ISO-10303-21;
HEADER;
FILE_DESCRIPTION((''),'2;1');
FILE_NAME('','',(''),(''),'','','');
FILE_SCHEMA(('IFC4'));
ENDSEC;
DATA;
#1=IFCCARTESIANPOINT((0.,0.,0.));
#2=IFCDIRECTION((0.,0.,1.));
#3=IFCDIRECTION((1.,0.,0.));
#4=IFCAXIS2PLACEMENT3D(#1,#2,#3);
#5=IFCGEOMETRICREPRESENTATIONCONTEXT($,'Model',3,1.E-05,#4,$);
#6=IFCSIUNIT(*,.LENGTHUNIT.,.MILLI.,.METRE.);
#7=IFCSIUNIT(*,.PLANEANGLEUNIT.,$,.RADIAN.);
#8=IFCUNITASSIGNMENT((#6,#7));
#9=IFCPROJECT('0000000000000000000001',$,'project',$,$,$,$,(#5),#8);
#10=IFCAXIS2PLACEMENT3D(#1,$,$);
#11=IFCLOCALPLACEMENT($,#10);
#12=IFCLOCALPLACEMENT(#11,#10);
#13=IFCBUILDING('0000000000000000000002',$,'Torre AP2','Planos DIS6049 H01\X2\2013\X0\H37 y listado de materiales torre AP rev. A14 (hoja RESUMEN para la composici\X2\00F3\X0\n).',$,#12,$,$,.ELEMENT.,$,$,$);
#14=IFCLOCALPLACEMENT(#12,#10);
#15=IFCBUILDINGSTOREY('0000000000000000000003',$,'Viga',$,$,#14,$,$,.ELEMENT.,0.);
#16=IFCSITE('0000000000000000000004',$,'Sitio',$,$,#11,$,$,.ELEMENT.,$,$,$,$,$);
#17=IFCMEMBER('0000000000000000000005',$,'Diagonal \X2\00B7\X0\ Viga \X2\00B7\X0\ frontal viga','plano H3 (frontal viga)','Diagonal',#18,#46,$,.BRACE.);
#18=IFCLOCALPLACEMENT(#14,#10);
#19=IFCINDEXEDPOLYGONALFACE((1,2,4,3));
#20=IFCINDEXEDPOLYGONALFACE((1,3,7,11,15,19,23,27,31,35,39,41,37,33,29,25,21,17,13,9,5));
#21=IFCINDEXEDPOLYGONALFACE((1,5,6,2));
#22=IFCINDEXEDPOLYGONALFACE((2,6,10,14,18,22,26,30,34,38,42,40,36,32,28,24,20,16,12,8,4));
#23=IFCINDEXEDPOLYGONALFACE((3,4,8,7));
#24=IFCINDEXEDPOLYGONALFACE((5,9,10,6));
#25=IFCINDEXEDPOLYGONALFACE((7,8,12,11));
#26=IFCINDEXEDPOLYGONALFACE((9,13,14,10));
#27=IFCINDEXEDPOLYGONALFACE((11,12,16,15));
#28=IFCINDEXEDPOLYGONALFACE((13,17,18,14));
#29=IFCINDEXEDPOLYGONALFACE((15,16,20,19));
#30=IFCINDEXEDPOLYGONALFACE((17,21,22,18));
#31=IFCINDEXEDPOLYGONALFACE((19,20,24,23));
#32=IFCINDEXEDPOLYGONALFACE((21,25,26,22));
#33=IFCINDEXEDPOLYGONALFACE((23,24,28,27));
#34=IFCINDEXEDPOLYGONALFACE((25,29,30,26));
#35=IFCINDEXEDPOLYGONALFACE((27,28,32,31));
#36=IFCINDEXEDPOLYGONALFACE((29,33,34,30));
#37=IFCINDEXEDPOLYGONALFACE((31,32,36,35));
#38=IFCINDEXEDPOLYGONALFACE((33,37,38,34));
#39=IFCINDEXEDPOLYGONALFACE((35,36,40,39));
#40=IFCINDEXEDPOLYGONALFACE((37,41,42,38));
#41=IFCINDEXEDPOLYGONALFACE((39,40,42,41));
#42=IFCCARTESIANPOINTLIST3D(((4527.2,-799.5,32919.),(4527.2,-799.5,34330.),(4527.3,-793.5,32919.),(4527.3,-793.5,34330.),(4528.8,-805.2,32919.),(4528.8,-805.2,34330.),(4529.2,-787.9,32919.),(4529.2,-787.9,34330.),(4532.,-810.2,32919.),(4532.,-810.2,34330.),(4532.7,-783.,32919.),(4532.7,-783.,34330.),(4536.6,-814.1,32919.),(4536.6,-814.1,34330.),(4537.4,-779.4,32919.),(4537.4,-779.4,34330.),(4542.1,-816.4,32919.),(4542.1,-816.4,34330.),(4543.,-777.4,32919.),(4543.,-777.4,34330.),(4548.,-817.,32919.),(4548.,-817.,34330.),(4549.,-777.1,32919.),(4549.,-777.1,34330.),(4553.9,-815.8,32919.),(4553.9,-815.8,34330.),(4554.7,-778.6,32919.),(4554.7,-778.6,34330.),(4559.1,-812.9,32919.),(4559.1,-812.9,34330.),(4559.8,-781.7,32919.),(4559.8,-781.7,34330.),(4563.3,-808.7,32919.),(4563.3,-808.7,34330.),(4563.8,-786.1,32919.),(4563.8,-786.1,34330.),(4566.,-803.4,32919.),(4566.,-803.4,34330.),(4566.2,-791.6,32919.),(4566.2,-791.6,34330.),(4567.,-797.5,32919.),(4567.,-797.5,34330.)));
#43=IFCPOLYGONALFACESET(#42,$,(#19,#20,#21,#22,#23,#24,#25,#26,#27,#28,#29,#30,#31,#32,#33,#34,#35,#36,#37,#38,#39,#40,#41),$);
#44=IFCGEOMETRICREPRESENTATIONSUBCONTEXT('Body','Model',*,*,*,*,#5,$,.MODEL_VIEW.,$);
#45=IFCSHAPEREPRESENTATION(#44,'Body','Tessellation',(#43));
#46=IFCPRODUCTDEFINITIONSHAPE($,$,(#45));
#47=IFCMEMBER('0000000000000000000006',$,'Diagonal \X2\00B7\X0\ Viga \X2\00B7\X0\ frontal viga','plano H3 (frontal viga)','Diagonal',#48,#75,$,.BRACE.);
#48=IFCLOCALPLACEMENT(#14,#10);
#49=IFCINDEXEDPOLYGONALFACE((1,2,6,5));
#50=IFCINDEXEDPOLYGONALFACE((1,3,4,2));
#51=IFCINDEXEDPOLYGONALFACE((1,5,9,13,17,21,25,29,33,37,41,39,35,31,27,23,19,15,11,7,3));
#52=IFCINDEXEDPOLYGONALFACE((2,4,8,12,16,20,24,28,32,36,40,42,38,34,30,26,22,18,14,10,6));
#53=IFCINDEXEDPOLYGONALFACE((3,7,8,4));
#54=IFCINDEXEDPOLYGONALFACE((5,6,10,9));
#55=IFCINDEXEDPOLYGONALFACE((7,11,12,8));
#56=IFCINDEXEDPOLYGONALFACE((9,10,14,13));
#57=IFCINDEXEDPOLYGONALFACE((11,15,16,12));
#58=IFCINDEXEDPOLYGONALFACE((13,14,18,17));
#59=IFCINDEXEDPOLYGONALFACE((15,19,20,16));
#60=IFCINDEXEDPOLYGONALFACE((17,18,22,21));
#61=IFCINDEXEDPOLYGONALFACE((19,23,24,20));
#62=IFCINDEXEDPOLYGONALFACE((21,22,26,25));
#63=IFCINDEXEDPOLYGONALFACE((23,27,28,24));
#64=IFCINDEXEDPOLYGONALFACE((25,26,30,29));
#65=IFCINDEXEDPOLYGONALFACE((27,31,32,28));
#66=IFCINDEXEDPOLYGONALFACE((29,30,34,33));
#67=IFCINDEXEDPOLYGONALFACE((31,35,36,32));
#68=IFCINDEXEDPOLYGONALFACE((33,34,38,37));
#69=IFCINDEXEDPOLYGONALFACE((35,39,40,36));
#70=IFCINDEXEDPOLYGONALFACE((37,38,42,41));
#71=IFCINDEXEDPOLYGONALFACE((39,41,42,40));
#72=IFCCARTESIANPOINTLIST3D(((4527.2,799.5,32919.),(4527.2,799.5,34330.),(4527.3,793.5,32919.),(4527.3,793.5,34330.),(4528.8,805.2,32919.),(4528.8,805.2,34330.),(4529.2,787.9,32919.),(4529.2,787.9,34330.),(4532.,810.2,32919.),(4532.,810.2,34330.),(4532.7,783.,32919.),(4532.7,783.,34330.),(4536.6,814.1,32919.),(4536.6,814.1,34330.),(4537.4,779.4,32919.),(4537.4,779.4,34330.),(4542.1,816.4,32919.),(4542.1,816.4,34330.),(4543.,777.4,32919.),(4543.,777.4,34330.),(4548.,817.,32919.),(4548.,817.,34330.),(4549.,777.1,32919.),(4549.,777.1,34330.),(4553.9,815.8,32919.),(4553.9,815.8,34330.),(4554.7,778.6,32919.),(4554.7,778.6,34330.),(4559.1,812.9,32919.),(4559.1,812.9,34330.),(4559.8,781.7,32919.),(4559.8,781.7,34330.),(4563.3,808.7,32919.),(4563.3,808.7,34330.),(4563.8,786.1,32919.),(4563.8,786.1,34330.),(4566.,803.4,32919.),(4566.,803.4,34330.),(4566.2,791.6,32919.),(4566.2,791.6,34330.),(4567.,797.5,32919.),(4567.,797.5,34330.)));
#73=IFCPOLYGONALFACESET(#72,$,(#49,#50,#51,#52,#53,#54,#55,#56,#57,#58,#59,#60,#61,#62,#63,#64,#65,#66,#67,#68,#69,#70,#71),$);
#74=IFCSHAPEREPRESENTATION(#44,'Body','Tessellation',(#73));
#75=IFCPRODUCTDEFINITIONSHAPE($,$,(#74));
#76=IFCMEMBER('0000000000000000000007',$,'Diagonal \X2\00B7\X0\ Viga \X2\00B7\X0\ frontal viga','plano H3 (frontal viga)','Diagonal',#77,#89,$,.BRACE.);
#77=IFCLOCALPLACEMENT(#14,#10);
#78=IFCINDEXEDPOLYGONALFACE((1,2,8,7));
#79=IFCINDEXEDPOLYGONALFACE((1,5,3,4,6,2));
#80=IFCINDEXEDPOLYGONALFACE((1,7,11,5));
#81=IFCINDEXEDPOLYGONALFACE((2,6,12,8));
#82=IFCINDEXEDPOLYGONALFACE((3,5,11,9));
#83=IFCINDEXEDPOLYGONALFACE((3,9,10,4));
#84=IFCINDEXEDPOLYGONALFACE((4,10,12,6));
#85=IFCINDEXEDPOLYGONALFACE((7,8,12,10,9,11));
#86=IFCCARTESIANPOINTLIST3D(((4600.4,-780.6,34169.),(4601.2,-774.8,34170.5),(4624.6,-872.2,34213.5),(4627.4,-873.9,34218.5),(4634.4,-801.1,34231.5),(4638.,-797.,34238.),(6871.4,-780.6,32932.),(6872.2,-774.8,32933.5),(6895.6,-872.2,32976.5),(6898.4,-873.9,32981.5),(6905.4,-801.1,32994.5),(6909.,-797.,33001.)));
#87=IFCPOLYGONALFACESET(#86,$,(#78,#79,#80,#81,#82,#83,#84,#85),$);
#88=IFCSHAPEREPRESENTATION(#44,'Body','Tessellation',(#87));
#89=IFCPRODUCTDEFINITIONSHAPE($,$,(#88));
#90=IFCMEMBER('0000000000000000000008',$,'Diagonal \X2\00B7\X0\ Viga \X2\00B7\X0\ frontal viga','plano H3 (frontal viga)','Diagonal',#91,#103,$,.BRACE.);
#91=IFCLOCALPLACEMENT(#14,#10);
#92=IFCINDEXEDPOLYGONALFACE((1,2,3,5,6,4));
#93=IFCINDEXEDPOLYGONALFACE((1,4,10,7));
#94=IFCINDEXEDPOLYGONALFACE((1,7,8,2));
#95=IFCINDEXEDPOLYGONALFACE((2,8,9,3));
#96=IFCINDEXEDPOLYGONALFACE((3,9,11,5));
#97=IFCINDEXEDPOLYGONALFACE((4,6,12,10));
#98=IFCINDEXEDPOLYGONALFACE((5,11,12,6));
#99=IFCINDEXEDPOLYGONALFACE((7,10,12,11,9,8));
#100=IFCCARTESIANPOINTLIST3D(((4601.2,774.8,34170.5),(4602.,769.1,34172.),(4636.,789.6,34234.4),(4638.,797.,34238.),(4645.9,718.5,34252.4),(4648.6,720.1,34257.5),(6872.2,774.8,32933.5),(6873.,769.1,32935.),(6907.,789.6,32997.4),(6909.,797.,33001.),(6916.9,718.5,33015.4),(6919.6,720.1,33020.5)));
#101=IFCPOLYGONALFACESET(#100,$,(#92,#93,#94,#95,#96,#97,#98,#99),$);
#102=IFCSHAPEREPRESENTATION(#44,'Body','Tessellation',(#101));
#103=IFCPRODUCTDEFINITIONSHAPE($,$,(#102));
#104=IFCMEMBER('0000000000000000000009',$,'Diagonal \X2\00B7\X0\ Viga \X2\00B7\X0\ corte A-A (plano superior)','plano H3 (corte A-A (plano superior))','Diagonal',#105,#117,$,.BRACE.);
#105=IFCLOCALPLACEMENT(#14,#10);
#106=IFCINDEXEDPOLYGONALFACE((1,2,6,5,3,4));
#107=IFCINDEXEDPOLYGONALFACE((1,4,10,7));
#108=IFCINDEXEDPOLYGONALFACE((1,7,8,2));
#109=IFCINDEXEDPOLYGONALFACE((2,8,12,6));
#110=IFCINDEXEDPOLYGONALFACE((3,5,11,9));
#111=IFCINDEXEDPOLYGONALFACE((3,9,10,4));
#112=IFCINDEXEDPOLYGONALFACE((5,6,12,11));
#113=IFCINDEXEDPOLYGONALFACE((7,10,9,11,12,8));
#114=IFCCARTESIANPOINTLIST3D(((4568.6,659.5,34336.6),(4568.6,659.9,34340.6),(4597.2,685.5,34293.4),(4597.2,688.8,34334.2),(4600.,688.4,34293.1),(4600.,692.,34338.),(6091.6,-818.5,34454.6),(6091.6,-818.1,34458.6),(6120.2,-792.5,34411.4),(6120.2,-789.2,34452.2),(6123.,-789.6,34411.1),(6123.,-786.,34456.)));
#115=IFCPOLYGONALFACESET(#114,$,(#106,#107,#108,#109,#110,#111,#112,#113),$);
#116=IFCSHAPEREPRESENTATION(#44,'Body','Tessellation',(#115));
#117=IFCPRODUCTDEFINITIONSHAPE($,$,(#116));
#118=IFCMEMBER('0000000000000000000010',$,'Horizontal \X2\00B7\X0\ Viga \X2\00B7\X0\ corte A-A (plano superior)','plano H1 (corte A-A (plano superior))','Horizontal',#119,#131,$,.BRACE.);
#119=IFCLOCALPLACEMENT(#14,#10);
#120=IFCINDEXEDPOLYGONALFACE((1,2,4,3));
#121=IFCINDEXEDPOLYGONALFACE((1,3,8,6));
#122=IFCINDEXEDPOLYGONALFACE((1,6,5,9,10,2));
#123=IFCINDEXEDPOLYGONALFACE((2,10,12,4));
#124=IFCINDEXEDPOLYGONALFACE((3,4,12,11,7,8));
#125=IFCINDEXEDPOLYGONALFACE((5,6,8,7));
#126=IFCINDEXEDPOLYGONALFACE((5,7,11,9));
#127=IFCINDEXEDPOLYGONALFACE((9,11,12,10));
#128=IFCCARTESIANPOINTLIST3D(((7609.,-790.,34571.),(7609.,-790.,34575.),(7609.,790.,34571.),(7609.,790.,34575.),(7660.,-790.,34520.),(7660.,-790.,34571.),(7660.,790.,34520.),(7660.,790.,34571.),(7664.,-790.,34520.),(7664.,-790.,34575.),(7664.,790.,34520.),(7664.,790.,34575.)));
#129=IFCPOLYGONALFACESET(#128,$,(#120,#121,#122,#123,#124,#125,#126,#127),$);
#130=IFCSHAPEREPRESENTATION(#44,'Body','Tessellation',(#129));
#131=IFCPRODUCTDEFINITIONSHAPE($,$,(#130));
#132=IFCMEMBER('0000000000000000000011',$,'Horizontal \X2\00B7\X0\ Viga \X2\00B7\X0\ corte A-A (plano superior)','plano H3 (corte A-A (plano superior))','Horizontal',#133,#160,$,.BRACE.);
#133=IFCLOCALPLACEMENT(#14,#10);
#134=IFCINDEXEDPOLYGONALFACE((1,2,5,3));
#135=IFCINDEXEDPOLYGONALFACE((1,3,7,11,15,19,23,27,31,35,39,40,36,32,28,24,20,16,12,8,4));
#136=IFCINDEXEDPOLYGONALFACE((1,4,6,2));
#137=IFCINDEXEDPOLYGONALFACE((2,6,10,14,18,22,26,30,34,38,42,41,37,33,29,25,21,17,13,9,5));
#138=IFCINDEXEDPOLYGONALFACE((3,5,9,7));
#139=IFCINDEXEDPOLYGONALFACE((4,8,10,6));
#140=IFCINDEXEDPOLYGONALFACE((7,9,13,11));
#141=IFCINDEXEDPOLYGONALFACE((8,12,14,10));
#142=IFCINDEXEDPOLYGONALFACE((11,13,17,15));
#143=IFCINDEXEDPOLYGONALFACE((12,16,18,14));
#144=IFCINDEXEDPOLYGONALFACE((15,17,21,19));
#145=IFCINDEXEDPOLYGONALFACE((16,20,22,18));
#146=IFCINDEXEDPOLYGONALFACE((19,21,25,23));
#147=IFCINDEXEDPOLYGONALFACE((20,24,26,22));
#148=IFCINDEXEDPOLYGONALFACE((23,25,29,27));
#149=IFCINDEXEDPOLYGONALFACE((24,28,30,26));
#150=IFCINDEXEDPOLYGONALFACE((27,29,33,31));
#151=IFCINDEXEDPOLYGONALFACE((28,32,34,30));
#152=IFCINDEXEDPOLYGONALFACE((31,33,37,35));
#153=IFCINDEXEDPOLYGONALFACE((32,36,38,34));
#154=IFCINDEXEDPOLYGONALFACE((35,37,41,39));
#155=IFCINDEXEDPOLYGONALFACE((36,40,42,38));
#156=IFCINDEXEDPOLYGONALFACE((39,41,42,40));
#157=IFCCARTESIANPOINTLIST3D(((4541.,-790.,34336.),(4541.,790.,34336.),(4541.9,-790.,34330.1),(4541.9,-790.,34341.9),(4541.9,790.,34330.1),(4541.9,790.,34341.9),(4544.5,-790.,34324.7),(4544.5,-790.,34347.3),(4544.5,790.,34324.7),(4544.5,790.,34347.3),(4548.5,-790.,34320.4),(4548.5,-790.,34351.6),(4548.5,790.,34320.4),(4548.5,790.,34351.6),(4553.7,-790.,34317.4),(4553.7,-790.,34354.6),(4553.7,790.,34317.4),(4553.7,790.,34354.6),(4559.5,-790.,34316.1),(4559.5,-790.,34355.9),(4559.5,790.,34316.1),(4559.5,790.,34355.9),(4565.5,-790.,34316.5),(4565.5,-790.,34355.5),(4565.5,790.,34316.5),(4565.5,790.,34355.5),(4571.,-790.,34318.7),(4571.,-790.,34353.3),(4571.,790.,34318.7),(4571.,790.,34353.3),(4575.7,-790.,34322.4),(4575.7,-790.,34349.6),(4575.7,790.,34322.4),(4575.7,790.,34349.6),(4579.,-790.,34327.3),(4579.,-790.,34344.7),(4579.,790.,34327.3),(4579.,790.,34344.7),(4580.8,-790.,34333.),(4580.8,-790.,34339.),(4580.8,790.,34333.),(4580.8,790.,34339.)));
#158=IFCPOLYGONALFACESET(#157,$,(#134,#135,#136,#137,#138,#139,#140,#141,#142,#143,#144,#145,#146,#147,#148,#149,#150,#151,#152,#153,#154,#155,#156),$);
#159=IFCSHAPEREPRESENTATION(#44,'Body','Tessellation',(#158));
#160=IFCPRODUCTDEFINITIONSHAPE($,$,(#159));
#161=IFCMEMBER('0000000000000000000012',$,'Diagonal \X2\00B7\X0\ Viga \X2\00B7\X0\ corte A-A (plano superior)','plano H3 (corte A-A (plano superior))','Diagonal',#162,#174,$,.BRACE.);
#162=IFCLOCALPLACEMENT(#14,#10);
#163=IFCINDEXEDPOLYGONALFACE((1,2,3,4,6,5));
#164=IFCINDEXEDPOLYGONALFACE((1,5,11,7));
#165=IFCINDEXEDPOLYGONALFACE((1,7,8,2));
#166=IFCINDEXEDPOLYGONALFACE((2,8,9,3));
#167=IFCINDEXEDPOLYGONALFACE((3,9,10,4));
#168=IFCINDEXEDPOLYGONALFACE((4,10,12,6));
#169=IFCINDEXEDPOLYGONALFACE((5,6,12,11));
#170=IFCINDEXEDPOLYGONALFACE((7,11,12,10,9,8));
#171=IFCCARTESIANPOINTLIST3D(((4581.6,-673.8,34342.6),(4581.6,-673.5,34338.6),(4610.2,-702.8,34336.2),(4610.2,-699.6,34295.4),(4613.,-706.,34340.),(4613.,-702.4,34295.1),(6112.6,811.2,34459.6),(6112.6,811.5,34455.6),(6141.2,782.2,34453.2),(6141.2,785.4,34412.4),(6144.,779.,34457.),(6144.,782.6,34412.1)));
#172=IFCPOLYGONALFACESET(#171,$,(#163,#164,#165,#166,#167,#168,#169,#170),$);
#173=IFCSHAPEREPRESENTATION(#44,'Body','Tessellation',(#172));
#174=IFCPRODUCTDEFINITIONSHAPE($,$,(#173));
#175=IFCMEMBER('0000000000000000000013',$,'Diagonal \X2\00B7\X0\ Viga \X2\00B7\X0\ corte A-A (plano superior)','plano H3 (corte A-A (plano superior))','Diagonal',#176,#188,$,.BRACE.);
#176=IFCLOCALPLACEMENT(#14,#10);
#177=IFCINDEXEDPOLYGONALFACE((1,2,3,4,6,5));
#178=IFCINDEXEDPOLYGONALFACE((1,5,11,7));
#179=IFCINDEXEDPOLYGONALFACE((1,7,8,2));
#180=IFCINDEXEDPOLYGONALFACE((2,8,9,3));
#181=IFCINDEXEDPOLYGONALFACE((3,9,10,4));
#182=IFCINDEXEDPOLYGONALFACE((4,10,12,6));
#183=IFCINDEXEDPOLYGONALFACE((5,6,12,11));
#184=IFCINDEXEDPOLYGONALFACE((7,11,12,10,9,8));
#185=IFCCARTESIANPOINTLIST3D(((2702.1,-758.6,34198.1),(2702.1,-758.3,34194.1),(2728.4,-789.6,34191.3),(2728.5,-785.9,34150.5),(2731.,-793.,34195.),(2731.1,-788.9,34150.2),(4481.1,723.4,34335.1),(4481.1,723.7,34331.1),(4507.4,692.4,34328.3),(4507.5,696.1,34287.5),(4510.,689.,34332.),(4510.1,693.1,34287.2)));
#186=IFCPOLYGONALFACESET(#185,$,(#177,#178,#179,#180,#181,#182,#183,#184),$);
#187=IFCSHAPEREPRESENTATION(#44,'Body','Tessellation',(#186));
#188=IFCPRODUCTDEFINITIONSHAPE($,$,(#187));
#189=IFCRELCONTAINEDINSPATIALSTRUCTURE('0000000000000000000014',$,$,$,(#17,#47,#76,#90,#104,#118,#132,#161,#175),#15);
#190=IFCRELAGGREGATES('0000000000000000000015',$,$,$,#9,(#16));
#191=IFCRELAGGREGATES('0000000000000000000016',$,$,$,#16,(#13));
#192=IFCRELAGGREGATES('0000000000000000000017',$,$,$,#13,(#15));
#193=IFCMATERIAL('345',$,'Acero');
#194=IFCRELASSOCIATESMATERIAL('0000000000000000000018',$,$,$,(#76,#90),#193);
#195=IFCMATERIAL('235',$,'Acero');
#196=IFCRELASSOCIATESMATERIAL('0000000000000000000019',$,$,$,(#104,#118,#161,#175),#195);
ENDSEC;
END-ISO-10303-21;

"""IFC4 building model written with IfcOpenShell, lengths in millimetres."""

from ifc_helpers import new_model, si_unit, frame, frame_2d, origin, origin_with_axes, place, context, subcontext, project, spatial, circle, l_section, extrude, material, element, save


model = new_model("IFC4")

# Units and contexts
model_context = context("Model", 3, precision=1e-05, world=origin_with_axes())
body_context = subcontext(model_context, "Body", "Model", "MODEL_VIEW")
ifc_project = project(units=[si_unit("LENGTHUNIT", "METRE", prefix="MILLI"), si_unit("PLANEANGLEUNIT", "RADIAN")], contexts=[model_context])

# Site, building, storey
site_placement = place(None, origin())
site = spatial("IfcSite", under=ifc_project, at=site_placement, Name="Sitio", CompositionType="ELEMENT")
building_placement = place(site_placement, origin())
building = spatial("IfcBuilding", under=site, at=building_placement, Name="Torre AP2", Description="Planos DIS6049 H01–H37 y listado de materiales torre AP rev. A14 (hoja RESUMEN para la composición).", CompositionType="ELEMENT")
storey_placement = place(building_placement, origin())
storey = spatial("IfcBuildingStorey", under=building, at=storey_placement, Name="Viga", CompositionType="ELEMENT", Elevation=0.0)

# Members
ifc_material_1 = material(Name="235", Category="Acero")
ifc_material_2 = material(Name="345", Category="Acero")
for number, where, z_axis, x_axis, name in (
    (1, (4547.0, -797.0, 32919.0), (0.0, 0.0, 1.0), (-0.984984, 0.172648, 0.0), "Diagonal · Viga · frontal viga"),
    (2, (4547.0, 797.0, 32919.0), (0.0, 0.0, 1.0), (-0.984984, -0.172648, 0.0), "Diagonal · Viga · frontal viga"),
):
    element("IfcMember", number, at=place(storey_placement, frame(where, z_axis=z_axis, x_axis=x_axis)), inside=storey, Name=name, Description="plano H3 (frontal viga)", ObjectType="Diagonal", PredefinedType="BRACE", context=body_context, shape_type="SweptSolid", body=[
        extrude(circle(Radius=20.0), None, (0.0, 0.0, 1.0), 1411.0),
    ])
for number, where, z_axis, x_axis, name in (
    (3, (6909.0, -797.0, 33001.0), (-0.878176, 0.0, 0.478337), (-0.459582, 0.277277, -0.843743), "Diagonal · Viga · frontal viga"),
    (4, (6909.0, 797.0, 33001.0), (-0.878176, 0.0, 0.478337), (-0.459582, -0.277277, -0.843743), "Diagonal · Viga · frontal viga"),
):
    element("IfcMember", number, at=place(storey_placement, frame(where, z_axis=z_axis, x_axis=x_axis)), inside=storey, material=ifc_material_2, Name=name, Description="plano H3 (frontal viga)", ObjectType="Diagonal", PredefinedType="BRACE", context=body_context, shape_type="SweptSolid", body=[
        extrude(l_section(Depth=80.0, Width=80.0, Thickness=6.0, at=frame_2d((40.0, 40.0))), None, (0.0, 0.0, 1.0), 2586.0),
    ])
member_1_placement = place(storey_placement, frame((4600.0, 692.0, 34338.0), z_axis=(0.716522, -0.695351, 0.055515), x_axis=(-0.697564, -0.714169, 0.05803)))
element("IfcMember", 5, at=member_1_placement, inside=storey, material=ifc_material_1, Name="Diagonal · Viga · corte A-A (plano superior)", Description="plano H3 (corte A-A (plano superior))", ObjectType="Diagonal", PredefinedType="BRACE", context=body_context, shape_type="SweptSolid", body=[
    extrude(l_section(Depth=45.0, Width=45.0, Thickness=4.0, at=frame_2d((22.5, 22.5))), None, (0.0, 0.0, 1.0), 2125.5),
])
member_2_placement = place(storey_placement, frame((7664.0, 790.0, 34575.0), z_axis=(0.0, -1.0, 0.0), x_axis=(-1.0, 0.0, 0.0)))
element("IfcMember", 6, at=member_2_placement, inside=storey, material=ifc_material_1, Name="Horizontal · Viga · corte A-A (plano superior)", Description="plano H1 (corte A-A (plano superior))", ObjectType="Horizontal", PredefinedType="BRACE", context=body_context, shape_type="SweptSolid", body=[
    extrude(l_section(Depth=55.0, Width=55.0, Thickness=4.0, at=frame_2d((27.5, 27.5))), None, (0.0, 0.0, 1.0), 1580.0),
])
member_3_placement = place(storey_placement, frame((4561.0, 790.0, 34336.0), z_axis=(0.0, -1.0, 0.0), x_axis=(-1.0, 0.0, 0.0)))
element("IfcMember", 7, at=member_3_placement, inside=storey, Name="Horizontal · Viga · corte A-A (plano superior)", Description="plano H3 (corte A-A (plano superior))", ObjectType="Horizontal", PredefinedType="BRACE", context=body_context, shape_type="SweptSolid", body=[
    extrude(circle(Radius=20.0), None, (0.0, 0.0, 1.0), 1580.0),
])
member_4_placement = place(storey_placement, frame((6144.0, 779.0, 34457.0), z_axis=(-0.716731, -0.695196, -0.054773), x_axis=(-0.69735, 0.714456, 0.057063)))
element("IfcMember", 8, at=member_4_placement, inside=storey, material=ifc_material_1, Name="Diagonal · Viga · corte A-A (plano superior)", Description="plano H3 (corte A-A (plano superior))", ObjectType="Diagonal", PredefinedType="BRACE", context=body_context, shape_type="SweptSolid", body=[
    extrude(l_section(Depth=45.0, Width=45.0, Thickness=4.0, at=frame_2d((22.5, 22.5))), None, (0.0, 0.0, 1.0), 2136.1),
])
member_5_placement = place(storey_placement, frame((4510.0, 689.0, 34332.0), z_axis=(-0.766986, -0.638939, -0.059065), x_axis=(-0.641662, 0.763915, 0.068584)))
element("IfcMember", 9, at=member_5_placement, inside=storey, material=ifc_material_1, Name="Diagonal · Viga · corte A-A (plano superior)", Description="plano H3 (corte A-A (plano superior))", ObjectType="Diagonal", PredefinedType="BRACE", context=body_context, shape_type="SweptSolid", body=[
    extrude(l_section(Depth=45.0, Width=45.0, Thickness=4.0, at=frame_2d((22.5, 22.5))), None, (0.0, 0.0, 1.0), 2319.5),
])

save(model, "model.ifc")
